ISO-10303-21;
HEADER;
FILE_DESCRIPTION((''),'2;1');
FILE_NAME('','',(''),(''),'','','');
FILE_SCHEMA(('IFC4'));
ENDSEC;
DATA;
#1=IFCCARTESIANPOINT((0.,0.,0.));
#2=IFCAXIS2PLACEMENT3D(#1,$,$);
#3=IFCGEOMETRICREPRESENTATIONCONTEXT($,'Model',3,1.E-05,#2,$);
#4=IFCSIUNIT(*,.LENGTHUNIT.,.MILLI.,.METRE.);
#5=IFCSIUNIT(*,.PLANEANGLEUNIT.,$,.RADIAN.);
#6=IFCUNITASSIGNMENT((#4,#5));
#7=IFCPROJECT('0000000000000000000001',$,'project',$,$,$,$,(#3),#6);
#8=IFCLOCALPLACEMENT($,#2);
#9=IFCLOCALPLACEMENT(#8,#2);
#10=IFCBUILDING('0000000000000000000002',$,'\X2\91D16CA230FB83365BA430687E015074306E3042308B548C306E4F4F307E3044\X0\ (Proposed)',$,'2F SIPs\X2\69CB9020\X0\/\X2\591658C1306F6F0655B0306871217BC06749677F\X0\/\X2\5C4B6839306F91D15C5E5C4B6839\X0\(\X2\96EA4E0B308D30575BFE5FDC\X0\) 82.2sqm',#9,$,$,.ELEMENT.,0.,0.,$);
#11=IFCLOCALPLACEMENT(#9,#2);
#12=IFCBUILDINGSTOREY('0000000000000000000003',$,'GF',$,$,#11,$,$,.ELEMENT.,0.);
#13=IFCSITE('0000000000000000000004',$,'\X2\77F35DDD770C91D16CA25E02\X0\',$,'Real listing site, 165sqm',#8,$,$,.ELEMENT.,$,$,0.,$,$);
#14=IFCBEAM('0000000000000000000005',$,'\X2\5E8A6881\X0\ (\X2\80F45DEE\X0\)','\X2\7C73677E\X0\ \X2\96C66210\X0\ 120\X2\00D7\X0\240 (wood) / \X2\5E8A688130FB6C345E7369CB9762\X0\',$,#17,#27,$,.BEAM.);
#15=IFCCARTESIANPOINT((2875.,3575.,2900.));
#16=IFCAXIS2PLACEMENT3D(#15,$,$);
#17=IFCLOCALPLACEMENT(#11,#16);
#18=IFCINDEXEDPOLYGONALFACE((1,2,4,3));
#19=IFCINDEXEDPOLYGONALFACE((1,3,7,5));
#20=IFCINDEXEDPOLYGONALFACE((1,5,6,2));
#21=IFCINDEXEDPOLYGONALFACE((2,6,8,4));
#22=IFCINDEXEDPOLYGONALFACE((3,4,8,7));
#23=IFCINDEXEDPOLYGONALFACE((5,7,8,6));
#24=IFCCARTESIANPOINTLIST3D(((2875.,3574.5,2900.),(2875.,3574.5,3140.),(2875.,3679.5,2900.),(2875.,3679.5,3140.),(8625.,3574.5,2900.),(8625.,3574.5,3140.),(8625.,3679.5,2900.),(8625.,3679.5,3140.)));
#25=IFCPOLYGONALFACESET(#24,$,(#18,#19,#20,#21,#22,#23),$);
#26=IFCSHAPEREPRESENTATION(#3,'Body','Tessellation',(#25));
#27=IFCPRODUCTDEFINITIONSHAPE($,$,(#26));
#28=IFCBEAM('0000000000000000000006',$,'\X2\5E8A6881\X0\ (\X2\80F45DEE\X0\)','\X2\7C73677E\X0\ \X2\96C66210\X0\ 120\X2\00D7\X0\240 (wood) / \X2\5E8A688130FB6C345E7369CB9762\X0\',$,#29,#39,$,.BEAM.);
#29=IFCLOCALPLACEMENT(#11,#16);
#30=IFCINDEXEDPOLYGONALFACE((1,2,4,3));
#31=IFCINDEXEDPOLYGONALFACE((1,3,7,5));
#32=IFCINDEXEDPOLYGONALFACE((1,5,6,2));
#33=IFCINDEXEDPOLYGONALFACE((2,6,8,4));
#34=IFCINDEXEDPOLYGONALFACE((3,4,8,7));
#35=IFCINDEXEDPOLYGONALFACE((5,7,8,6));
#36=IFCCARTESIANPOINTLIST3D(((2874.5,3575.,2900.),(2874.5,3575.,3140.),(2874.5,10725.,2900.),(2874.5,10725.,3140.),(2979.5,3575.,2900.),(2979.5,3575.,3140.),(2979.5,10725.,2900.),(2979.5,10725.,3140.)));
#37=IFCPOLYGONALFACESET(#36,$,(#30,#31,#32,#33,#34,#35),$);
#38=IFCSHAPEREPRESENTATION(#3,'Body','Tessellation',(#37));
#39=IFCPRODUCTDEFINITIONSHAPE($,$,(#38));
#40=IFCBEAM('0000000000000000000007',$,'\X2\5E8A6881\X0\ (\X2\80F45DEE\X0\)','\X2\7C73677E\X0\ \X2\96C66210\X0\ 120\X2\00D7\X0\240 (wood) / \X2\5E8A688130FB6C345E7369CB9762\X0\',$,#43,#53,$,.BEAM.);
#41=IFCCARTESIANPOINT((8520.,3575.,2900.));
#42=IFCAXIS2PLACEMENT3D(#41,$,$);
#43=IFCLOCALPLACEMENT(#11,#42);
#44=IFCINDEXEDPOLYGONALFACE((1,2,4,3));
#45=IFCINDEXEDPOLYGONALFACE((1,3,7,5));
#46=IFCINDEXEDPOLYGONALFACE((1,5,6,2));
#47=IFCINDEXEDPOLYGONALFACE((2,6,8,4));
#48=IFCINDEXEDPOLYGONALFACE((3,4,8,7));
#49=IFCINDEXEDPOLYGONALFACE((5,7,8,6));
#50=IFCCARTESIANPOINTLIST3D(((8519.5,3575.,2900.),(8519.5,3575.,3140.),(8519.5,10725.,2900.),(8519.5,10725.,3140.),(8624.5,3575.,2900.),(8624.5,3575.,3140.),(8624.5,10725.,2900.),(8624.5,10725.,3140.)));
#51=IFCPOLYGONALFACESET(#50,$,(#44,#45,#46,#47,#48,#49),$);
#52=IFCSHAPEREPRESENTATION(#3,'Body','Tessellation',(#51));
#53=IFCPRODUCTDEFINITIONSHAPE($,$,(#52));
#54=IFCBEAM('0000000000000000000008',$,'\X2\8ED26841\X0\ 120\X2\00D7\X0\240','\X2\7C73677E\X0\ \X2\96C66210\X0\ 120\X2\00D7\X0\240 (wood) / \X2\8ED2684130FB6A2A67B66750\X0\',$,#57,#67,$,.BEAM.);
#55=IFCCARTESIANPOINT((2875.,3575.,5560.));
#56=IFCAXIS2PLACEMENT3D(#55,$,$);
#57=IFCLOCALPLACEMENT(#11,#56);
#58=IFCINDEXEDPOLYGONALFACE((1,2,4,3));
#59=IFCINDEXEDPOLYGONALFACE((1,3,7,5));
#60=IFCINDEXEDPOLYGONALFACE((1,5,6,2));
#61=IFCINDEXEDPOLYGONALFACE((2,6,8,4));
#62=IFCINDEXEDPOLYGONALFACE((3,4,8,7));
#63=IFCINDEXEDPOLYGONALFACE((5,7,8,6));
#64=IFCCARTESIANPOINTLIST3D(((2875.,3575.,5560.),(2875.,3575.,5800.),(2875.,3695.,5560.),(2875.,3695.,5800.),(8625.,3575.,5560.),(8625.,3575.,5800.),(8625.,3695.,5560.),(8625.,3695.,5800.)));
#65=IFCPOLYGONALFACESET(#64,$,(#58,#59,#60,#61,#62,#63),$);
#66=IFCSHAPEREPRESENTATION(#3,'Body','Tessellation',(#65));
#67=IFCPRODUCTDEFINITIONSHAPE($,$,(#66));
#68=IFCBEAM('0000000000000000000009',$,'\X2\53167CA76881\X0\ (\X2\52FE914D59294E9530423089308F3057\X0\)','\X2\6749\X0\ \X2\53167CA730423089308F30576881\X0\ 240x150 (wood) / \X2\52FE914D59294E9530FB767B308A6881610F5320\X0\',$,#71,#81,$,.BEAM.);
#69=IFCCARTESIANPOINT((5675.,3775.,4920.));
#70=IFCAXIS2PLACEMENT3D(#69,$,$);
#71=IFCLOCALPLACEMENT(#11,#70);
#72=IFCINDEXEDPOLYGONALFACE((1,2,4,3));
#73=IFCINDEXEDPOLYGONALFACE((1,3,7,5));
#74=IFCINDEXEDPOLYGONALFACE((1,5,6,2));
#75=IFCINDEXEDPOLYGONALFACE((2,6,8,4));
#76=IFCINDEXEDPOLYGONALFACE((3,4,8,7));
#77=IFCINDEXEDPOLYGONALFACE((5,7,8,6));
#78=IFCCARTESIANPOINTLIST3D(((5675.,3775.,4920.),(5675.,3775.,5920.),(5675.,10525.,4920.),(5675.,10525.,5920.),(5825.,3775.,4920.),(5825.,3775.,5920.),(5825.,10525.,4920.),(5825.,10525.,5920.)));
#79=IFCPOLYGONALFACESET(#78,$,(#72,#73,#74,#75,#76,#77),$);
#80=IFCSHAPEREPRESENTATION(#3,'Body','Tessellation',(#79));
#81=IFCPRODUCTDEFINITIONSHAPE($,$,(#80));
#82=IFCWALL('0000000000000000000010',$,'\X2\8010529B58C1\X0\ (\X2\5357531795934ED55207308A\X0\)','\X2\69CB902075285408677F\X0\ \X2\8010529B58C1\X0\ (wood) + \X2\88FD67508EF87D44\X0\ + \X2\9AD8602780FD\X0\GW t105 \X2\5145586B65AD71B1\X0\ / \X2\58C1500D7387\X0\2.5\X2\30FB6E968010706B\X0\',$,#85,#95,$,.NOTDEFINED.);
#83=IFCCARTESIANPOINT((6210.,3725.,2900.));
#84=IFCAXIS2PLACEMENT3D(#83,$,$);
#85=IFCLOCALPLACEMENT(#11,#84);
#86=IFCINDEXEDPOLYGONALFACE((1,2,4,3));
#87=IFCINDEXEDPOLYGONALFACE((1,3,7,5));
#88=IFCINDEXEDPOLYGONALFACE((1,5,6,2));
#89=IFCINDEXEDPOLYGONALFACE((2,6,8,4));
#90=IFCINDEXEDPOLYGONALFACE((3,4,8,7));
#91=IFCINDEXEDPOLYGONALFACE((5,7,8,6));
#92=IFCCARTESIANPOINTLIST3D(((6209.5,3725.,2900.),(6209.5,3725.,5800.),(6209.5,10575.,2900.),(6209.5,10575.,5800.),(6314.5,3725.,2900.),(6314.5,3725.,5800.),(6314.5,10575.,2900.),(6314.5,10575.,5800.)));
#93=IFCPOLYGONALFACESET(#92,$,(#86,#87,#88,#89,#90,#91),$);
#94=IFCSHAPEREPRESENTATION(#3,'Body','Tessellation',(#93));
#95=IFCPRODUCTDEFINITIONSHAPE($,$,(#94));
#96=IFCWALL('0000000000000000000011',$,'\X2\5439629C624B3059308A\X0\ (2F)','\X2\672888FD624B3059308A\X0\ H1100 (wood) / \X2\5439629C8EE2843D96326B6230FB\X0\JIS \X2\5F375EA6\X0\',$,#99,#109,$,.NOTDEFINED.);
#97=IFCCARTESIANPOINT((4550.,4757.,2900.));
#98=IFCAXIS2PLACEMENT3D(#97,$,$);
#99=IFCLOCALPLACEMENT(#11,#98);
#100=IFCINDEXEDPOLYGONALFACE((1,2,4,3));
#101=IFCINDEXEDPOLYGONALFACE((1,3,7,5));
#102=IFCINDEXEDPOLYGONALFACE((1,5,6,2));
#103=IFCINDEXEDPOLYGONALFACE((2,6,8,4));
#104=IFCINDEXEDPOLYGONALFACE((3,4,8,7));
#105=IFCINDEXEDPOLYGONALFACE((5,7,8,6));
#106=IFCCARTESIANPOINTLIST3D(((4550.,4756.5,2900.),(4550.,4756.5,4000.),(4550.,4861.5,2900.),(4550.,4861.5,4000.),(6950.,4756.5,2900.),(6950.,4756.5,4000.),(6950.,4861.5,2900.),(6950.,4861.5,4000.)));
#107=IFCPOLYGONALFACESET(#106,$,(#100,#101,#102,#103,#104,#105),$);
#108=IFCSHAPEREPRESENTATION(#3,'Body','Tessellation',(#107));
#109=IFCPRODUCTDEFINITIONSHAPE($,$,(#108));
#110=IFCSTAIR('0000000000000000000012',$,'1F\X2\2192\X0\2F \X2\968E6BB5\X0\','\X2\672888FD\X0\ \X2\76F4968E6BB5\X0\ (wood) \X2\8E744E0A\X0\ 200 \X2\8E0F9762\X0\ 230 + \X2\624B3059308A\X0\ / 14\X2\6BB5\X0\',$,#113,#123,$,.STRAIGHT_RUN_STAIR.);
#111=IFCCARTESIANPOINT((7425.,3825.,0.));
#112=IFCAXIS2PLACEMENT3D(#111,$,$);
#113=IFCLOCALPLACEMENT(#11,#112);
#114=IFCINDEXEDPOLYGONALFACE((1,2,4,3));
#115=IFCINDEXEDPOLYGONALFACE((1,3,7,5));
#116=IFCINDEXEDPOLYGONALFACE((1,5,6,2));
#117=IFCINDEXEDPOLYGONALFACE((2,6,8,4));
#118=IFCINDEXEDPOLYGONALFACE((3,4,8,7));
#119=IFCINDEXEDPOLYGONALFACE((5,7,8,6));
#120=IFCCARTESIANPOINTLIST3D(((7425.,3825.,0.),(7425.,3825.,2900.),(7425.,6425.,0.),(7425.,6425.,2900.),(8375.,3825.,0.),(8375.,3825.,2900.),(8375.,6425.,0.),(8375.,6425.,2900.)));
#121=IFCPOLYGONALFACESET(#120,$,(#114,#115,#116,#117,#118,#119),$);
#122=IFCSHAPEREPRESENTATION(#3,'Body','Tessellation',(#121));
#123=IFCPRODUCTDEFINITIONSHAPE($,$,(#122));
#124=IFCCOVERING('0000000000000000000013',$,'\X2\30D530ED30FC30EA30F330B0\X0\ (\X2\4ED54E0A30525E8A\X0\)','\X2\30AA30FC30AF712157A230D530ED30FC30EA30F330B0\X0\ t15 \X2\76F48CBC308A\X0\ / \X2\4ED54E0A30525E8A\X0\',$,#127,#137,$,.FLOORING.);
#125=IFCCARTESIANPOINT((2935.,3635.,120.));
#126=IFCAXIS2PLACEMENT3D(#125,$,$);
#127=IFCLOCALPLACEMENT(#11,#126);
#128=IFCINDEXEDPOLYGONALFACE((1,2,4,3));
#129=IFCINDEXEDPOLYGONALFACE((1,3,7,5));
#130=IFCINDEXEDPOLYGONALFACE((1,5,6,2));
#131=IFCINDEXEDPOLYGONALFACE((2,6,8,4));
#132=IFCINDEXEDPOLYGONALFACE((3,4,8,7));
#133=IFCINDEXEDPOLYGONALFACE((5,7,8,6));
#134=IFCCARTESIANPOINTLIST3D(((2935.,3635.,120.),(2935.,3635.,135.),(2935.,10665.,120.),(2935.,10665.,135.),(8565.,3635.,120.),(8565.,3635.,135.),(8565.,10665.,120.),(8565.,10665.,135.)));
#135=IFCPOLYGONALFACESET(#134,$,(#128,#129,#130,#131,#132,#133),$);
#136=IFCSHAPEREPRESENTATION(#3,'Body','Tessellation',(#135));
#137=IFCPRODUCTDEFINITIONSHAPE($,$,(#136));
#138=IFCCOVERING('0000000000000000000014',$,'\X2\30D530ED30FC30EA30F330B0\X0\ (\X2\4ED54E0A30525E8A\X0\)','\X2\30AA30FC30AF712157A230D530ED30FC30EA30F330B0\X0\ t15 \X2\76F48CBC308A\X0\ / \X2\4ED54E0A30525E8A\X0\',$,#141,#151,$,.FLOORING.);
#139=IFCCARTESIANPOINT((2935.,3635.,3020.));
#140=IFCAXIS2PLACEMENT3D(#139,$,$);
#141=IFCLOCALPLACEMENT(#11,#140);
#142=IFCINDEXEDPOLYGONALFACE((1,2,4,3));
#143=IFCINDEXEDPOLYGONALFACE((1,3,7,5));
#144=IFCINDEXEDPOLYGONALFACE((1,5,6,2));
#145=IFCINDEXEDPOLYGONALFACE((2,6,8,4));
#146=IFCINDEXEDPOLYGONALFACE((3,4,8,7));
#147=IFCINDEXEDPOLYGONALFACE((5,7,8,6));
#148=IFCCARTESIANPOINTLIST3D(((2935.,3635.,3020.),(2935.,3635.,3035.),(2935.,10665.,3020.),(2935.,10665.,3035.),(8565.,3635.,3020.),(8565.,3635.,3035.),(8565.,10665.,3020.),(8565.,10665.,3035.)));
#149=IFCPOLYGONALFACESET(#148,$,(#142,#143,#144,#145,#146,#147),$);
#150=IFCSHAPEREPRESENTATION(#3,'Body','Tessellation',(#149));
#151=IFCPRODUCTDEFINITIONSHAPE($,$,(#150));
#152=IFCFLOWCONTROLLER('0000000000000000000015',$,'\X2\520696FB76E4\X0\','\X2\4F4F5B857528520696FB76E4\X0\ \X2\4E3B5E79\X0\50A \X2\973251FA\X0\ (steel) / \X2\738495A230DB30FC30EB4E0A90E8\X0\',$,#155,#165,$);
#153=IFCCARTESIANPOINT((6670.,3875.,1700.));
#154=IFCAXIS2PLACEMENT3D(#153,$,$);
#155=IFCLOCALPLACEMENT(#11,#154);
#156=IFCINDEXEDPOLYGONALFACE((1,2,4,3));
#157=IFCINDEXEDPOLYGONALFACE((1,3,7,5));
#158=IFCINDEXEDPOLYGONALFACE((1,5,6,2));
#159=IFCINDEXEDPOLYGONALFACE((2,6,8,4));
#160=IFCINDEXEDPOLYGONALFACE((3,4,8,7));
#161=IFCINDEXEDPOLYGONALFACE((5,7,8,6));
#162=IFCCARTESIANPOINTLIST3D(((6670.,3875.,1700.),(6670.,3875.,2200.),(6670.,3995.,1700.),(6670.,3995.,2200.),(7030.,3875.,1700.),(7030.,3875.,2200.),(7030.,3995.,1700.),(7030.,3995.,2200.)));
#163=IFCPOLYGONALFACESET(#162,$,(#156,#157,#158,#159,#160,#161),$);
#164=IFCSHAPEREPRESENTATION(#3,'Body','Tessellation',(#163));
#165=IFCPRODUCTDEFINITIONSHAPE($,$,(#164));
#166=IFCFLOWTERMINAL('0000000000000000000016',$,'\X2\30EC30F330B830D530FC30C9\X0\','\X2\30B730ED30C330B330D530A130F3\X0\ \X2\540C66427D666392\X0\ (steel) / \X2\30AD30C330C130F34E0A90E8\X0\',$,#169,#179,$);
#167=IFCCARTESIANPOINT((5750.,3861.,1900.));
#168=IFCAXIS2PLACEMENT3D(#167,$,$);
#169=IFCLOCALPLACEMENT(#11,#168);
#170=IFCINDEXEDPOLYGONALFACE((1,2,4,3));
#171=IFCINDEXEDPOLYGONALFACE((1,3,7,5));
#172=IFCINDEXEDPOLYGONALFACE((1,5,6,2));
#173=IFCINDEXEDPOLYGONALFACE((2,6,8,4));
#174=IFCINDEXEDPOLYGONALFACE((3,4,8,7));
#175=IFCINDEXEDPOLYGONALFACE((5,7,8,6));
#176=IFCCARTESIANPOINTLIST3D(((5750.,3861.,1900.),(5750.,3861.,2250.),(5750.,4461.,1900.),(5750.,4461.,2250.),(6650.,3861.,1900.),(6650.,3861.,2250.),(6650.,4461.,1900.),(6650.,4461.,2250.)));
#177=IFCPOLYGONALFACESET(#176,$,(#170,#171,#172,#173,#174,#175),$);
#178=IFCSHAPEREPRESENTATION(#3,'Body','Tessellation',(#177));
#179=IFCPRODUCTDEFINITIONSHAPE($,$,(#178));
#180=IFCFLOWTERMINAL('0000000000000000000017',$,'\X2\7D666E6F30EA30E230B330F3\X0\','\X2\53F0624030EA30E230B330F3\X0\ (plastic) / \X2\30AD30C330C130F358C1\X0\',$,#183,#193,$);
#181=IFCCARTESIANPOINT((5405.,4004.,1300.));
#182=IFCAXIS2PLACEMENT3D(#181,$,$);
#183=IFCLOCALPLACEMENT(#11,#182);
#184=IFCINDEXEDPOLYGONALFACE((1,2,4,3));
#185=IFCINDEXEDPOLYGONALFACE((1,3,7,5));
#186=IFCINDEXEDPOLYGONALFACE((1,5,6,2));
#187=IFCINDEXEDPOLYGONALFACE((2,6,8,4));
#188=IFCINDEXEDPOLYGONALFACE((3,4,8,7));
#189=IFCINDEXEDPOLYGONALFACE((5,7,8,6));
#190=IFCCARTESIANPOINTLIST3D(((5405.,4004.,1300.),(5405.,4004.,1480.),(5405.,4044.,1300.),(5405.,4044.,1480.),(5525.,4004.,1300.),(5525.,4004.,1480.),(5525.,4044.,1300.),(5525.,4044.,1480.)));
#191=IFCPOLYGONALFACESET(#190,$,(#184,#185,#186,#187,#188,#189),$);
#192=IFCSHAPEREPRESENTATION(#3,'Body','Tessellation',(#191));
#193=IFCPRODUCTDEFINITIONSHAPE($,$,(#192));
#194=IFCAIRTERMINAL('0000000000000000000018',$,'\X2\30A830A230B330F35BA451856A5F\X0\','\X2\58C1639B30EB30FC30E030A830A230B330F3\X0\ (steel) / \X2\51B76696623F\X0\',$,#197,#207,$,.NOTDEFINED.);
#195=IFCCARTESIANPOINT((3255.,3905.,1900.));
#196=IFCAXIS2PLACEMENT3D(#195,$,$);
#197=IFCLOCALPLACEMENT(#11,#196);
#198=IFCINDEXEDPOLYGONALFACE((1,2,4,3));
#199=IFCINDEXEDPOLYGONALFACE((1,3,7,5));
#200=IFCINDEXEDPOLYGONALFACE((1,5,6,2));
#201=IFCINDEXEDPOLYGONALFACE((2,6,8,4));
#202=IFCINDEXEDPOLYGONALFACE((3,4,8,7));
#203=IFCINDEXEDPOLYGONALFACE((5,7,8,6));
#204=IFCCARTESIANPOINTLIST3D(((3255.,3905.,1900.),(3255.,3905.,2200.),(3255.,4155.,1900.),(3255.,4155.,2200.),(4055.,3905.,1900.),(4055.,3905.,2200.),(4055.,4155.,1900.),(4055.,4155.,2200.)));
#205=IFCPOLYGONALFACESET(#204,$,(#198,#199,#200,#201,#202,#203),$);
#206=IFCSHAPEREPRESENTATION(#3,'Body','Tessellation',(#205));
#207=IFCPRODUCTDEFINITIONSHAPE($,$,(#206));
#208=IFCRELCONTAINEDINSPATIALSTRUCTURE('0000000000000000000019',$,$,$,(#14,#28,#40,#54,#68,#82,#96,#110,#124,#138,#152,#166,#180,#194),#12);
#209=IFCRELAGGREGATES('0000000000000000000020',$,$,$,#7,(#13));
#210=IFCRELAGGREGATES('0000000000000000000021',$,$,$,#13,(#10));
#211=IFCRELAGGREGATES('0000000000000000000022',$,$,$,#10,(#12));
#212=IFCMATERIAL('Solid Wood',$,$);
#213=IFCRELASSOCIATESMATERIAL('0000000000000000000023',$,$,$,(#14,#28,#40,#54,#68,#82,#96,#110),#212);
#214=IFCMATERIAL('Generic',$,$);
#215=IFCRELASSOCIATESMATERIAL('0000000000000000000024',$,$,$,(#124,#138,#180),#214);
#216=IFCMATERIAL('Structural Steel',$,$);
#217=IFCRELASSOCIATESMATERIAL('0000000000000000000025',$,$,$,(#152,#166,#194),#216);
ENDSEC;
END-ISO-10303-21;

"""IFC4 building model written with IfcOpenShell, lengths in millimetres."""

from ifc_helpers import new_model, si_unit, frame, frame_2d, origin, place, context, project, spatial, rectangle, extrude, material, element, save


model = new_model("IFC4")

# Units and contexts
model_context = context("Model", 3, precision=1e-05, world=origin())
ifc_project = project(units=[si_unit("LENGTHUNIT", "METRE", prefix="MILLI"), si_unit("PLANEANGLEUNIT", "RADIAN")], contexts=[model_context])

# Site, building, storey
site_placement = place(None, origin())
site = spatial("IfcSite", under=ifc_project, at=site_placement, Name="石川県金沢市", ObjectType="Real listing site, 165sqm", CompositionType="ELEMENT", RefElevation=0.0)
building_placement = place(site_placement, origin())
building = spatial("IfcBuilding", under=site, at=building_placement, Name="金沢・茶室と縁側のある和の住まい (Proposed)", ObjectType="2F SIPs構造/外壁は漆喰と無節杉板/屋根は金属屋根(雪下ろし対応) 82.2sqm", CompositionType="ELEMENT", ElevationOfRefHeight=0.0, ElevationOfTerrain=0.0)
storey_placement = place(building_placement, origin())
storey = spatial("IfcBuildingStorey", under=building, at=storey_placement, Name="GF", CompositionType="ELEMENT", Elevation=0.0)

# Shared definitions
ifc_material_1 = material(Name="Solid Wood")

# Beams
beam_1_placement = place(storey_placement, frame((2875.0, 3575.0, 2900.0)))
element("IfcBeam", 1, at=beam_1_placement, inside=storey, material=ifc_material_1, Name="床梁 (胴差)", Description="米松 集成 120×240 (wood) / 床梁・水平構面", PredefinedType="BEAM", context=model_context, shape_type="SweptSolid", body=[
    extrude(rectangle(XDim=5750.0, YDim=105.0, at=frame_2d((2875.0, 52.0))), frame((2875.0, 3575.0, 2900.0)), (0.0, 0.0, 1.0), 240.0),
])
beam_2_placement = place(storey_placement, frame((2875.0, 3575.0, 2900.0)))
element("IfcBeam", 2, at=beam_2_placement, inside=storey, material=ifc_material_1, Name="床梁 (胴差)", Description="米松 集成 120×240 (wood) / 床梁・水平構面", PredefinedType="BEAM", context=model_context, shape_type="SweptSolid", body=[
    extrude(rectangle(XDim=105.0, YDim=7150.0, at=frame_2d((52.0, 3575.0))), frame((2875.0, 3575.0, 2900.0)), (0.0, 0.0, 1.0), 240.0),
])
beam_3_placement = place(storey_placement, frame((8520.0, 3575.0, 2900.0)))
element("IfcBeam", 3, at=beam_3_placement, inside=storey, material=ifc_material_1, Name="床梁 (胴差)", Description="米松 集成 120×240 (wood) / 床梁・水平構面", PredefinedType="BEAM", context=model_context, shape_type="SweptSolid", body=[
    extrude(rectangle(XDim=105.0, YDim=7150.0, at=frame_2d((52.0, 3575.0))), frame((8520.0, 3575.0, 2900.0)), (0.0, 0.0, 1.0), 240.0),
])
beam_4_placement = place(storey_placement, frame((2875.0, 3575.0, 5560.0)))
element("IfcBeam", 4, at=beam_4_placement, inside=storey, material=ifc_material_1, Name="軒桁 120×240", Description="米松 集成 120×240 (wood) / 軒桁・横架材", PredefinedType="BEAM", context=model_context, shape_type="SweptSolid", body=[
    extrude(rectangle(XDim=5750.0, YDim=120.0, at=frame_2d((2875.0, 60.0))), frame((2875.0, 3575.0, 5560.0)), (0.0, 0.0, 1.0), 240.0),
])
beam_5_placement = place(storey_placement, frame((5675.0, 3775.0, 4920.0)))
element("IfcBeam", 5, at=beam_5_placement, inside=storey, material=ifc_material_1, Name="化粧梁 (勾配天井あらわし)", Description="杉 化粧あらわし梁 240x150 (wood) / 勾配天井・登り梁意匠", PredefinedType="BEAM", context=model_context, shape_type="SweptSolid", body=[
    extrude(rectangle(XDim=150.0, YDim=6750.0, at=frame_2d((75.0, 3375.0))), frame((5675.0, 3775.0, 4920.0)), (0.0, 0.0, 1.0), 1000.0),
])

# Walls
wall_1_placement = place(storey_placement, frame((6210.0, 3725.0, 2900.0)))
element("IfcWall", 6, at=wall_1_placement, inside=storey, material=ifc_material_1, Name="耐力壁 (南北間仕切り)", Description="構造用合板 耐力壁 (wood) + 製材軸組 + 高性能GW t105 充填断熱 / 壁倍率2.5・準耐火", PredefinedType="NOTDEFINED", context=model_context, shape_type="SweptSolid", body=[
    extrude(rectangle(XDim=105.0, YDim=6850.0, at=frame_2d((52.0, 3425.0))), frame((6210.0, 3725.0, 2900.0)), (0.0, 0.0, 1.0), 2900.0),
])
wall_2_placement = place(storey_placement, frame((4550.0, 4757.0, 2900.0)))
element("IfcWall", 7, at=wall_2_placement, inside=storey, material=ifc_material_1, Name="吹抜手すり (2F)", Description="木製手すり H1100 (wood) / 吹抜転落防止・JIS 強度", PredefinedType="NOTDEFINED", context=model_context, shape_type="SweptSolid", body=[
    extrude(rectangle(XDim=2400.0, YDim=105.0, at=frame_2d((1200.0, 52.0))), frame((4550.0, 4757.0, 2900.0)), (0.0, 0.0, 1.0), 1100.0),
])

# Stair
stair_placement = place(storey_placement, frame((7425.0, 3825.0, 0.0)))
element("IfcStair", 8, at=stair_placement, inside=storey, material=ifc_material_1, Name="1F→2F 階段", Description="木製 直階段 (wood) 蹴上 200 踏面 230 + 手すり / 14段", PredefinedType="STRAIGHT_RUN_STAIR", context=model_context, shape_type="SweptSolid", body=[
    extrude(rectangle(XDim=950.0, YDim=2600.0, at=frame_2d((475.0, 1300.0))), frame((7425.0, 3825.0, 0.0)), (0.0, 0.0, 1.0), 2900.0),
])

# Coverings
ifc_material_2 = material(Name="Generic")
covering_1_placement = place(storey_placement, frame((2935.0, 3635.0, 120.0)))
element("IfcCovering", 9, at=covering_1_placement, inside=storey, material=ifc_material_2, Name="フローリング (仕上げ床)", Description="オーク無垢フローリング t15 直貼り / 仕上げ床", PredefinedType="FLOORING", context=model_context, shape_type="SweptSolid", body=[
    extrude(rectangle(XDim=5630.0, YDim=7030.0, at=frame_2d((2815.0, 3515.0))), frame((2935.0, 3635.0, 120.0)), (0.0, 0.0, 1.0), 15.0),
])
covering_2_placement = place(storey_placement, frame((2935.0, 3635.0, 3020.0)))
element("IfcCovering", 10, at=covering_2_placement, inside=storey, material=ifc_material_2, Name="フローリング (仕上げ床)", Description="オーク無垢フローリング t15 直貼り / 仕上げ床", PredefinedType="FLOORING", context=model_context, shape_type="SweptSolid", body=[
    extrude(rectangle(XDim=5630.0, YDim=7030.0, at=frame_2d((2815.0, 3515.0))), frame((2935.0, 3635.0, 3020.0)), (0.0, 0.0, 1.0), 15.0),
])

# Flow controller
ifc_material_3 = material(Name="Structural Steel")
flow_controller_placement = place(storey_placement, frame((6670.0, 3875.0, 1700.0)))
element("IfcFlowController", 11, at=flow_controller_placement, inside=storey, material=ifc_material_3, Name="分電盤", Description="住宅用分電盤 主幹50A 露出 (steel) / 玄関ホール上部", context=model_context, shape_type="SweptSolid", body=[
    extrude(rectangle(XDim=360.0, YDim=120.0, at=frame_2d((180.0, 60.0))), frame((6670.0, 3875.0, 1700.0)), (0.0, 0.0, 1.0), 500.0),
])

# Flow terminals
flow_terminal_1_placement = place(storey_placement, frame((5750.0, 3861.0, 1900.0)))
element("IfcFlowTerminal", 12, at=flow_terminal_1_placement, inside=storey, material=ifc_material_3, Name="レンジフード", Description="シロッコファン 同時給排 (steel) / キッチン上部", context=model_context, shape_type="SweptSolid", body=[
    extrude(rectangle(XDim=900.0, YDim=600.0, at=frame_2d((450.0, 300.0))), frame((5750.0, 3861.0, 1900.0)), (0.0, 0.0, 1.0), 350.0),
])
flow_terminal_2_placement = place(storey_placement, frame((5405.0, 4004.0, 1300.0)))
element("IfcFlowTerminal", 13, at=flow_terminal_2_placement, inside=storey, material=ifc_material_2, Name="給湯リモコン", Description="台所リモコン (plastic) / キッチン壁", context=model_context, shape_type="SweptSolid", body=[
    extrude(rectangle(XDim=120.0, YDim=40.0, at=frame_2d((60.0, 20.0))), frame((5405.0, 4004.0, 1300.0)), (0.0, 0.0, 1.0), 180.0),
])

# Air terminal
air_terminal_1_placement = place(storey_placement, frame((3255.0, 3905.0, 1900.0)))
element("IfcAirTerminal", 14, at=air_terminal_1_placement, inside=storey, material=ifc_material_3, Name="エアコン室内機", Description="壁掛ルームエアコン (steel) / 冷暖房", PredefinedType="NOTDEFINED", context=model_context, shape_type="SweptSolid", body=[
    extrude(rectangle(XDim=800.0, YDim=250.0, at=frame_2d((400.0, 125.0))), frame((3255.0, 3905.0, 1900.0)), (0.0, 0.0, 1.0), 300.0),
])

save(model, "model.ifc")
